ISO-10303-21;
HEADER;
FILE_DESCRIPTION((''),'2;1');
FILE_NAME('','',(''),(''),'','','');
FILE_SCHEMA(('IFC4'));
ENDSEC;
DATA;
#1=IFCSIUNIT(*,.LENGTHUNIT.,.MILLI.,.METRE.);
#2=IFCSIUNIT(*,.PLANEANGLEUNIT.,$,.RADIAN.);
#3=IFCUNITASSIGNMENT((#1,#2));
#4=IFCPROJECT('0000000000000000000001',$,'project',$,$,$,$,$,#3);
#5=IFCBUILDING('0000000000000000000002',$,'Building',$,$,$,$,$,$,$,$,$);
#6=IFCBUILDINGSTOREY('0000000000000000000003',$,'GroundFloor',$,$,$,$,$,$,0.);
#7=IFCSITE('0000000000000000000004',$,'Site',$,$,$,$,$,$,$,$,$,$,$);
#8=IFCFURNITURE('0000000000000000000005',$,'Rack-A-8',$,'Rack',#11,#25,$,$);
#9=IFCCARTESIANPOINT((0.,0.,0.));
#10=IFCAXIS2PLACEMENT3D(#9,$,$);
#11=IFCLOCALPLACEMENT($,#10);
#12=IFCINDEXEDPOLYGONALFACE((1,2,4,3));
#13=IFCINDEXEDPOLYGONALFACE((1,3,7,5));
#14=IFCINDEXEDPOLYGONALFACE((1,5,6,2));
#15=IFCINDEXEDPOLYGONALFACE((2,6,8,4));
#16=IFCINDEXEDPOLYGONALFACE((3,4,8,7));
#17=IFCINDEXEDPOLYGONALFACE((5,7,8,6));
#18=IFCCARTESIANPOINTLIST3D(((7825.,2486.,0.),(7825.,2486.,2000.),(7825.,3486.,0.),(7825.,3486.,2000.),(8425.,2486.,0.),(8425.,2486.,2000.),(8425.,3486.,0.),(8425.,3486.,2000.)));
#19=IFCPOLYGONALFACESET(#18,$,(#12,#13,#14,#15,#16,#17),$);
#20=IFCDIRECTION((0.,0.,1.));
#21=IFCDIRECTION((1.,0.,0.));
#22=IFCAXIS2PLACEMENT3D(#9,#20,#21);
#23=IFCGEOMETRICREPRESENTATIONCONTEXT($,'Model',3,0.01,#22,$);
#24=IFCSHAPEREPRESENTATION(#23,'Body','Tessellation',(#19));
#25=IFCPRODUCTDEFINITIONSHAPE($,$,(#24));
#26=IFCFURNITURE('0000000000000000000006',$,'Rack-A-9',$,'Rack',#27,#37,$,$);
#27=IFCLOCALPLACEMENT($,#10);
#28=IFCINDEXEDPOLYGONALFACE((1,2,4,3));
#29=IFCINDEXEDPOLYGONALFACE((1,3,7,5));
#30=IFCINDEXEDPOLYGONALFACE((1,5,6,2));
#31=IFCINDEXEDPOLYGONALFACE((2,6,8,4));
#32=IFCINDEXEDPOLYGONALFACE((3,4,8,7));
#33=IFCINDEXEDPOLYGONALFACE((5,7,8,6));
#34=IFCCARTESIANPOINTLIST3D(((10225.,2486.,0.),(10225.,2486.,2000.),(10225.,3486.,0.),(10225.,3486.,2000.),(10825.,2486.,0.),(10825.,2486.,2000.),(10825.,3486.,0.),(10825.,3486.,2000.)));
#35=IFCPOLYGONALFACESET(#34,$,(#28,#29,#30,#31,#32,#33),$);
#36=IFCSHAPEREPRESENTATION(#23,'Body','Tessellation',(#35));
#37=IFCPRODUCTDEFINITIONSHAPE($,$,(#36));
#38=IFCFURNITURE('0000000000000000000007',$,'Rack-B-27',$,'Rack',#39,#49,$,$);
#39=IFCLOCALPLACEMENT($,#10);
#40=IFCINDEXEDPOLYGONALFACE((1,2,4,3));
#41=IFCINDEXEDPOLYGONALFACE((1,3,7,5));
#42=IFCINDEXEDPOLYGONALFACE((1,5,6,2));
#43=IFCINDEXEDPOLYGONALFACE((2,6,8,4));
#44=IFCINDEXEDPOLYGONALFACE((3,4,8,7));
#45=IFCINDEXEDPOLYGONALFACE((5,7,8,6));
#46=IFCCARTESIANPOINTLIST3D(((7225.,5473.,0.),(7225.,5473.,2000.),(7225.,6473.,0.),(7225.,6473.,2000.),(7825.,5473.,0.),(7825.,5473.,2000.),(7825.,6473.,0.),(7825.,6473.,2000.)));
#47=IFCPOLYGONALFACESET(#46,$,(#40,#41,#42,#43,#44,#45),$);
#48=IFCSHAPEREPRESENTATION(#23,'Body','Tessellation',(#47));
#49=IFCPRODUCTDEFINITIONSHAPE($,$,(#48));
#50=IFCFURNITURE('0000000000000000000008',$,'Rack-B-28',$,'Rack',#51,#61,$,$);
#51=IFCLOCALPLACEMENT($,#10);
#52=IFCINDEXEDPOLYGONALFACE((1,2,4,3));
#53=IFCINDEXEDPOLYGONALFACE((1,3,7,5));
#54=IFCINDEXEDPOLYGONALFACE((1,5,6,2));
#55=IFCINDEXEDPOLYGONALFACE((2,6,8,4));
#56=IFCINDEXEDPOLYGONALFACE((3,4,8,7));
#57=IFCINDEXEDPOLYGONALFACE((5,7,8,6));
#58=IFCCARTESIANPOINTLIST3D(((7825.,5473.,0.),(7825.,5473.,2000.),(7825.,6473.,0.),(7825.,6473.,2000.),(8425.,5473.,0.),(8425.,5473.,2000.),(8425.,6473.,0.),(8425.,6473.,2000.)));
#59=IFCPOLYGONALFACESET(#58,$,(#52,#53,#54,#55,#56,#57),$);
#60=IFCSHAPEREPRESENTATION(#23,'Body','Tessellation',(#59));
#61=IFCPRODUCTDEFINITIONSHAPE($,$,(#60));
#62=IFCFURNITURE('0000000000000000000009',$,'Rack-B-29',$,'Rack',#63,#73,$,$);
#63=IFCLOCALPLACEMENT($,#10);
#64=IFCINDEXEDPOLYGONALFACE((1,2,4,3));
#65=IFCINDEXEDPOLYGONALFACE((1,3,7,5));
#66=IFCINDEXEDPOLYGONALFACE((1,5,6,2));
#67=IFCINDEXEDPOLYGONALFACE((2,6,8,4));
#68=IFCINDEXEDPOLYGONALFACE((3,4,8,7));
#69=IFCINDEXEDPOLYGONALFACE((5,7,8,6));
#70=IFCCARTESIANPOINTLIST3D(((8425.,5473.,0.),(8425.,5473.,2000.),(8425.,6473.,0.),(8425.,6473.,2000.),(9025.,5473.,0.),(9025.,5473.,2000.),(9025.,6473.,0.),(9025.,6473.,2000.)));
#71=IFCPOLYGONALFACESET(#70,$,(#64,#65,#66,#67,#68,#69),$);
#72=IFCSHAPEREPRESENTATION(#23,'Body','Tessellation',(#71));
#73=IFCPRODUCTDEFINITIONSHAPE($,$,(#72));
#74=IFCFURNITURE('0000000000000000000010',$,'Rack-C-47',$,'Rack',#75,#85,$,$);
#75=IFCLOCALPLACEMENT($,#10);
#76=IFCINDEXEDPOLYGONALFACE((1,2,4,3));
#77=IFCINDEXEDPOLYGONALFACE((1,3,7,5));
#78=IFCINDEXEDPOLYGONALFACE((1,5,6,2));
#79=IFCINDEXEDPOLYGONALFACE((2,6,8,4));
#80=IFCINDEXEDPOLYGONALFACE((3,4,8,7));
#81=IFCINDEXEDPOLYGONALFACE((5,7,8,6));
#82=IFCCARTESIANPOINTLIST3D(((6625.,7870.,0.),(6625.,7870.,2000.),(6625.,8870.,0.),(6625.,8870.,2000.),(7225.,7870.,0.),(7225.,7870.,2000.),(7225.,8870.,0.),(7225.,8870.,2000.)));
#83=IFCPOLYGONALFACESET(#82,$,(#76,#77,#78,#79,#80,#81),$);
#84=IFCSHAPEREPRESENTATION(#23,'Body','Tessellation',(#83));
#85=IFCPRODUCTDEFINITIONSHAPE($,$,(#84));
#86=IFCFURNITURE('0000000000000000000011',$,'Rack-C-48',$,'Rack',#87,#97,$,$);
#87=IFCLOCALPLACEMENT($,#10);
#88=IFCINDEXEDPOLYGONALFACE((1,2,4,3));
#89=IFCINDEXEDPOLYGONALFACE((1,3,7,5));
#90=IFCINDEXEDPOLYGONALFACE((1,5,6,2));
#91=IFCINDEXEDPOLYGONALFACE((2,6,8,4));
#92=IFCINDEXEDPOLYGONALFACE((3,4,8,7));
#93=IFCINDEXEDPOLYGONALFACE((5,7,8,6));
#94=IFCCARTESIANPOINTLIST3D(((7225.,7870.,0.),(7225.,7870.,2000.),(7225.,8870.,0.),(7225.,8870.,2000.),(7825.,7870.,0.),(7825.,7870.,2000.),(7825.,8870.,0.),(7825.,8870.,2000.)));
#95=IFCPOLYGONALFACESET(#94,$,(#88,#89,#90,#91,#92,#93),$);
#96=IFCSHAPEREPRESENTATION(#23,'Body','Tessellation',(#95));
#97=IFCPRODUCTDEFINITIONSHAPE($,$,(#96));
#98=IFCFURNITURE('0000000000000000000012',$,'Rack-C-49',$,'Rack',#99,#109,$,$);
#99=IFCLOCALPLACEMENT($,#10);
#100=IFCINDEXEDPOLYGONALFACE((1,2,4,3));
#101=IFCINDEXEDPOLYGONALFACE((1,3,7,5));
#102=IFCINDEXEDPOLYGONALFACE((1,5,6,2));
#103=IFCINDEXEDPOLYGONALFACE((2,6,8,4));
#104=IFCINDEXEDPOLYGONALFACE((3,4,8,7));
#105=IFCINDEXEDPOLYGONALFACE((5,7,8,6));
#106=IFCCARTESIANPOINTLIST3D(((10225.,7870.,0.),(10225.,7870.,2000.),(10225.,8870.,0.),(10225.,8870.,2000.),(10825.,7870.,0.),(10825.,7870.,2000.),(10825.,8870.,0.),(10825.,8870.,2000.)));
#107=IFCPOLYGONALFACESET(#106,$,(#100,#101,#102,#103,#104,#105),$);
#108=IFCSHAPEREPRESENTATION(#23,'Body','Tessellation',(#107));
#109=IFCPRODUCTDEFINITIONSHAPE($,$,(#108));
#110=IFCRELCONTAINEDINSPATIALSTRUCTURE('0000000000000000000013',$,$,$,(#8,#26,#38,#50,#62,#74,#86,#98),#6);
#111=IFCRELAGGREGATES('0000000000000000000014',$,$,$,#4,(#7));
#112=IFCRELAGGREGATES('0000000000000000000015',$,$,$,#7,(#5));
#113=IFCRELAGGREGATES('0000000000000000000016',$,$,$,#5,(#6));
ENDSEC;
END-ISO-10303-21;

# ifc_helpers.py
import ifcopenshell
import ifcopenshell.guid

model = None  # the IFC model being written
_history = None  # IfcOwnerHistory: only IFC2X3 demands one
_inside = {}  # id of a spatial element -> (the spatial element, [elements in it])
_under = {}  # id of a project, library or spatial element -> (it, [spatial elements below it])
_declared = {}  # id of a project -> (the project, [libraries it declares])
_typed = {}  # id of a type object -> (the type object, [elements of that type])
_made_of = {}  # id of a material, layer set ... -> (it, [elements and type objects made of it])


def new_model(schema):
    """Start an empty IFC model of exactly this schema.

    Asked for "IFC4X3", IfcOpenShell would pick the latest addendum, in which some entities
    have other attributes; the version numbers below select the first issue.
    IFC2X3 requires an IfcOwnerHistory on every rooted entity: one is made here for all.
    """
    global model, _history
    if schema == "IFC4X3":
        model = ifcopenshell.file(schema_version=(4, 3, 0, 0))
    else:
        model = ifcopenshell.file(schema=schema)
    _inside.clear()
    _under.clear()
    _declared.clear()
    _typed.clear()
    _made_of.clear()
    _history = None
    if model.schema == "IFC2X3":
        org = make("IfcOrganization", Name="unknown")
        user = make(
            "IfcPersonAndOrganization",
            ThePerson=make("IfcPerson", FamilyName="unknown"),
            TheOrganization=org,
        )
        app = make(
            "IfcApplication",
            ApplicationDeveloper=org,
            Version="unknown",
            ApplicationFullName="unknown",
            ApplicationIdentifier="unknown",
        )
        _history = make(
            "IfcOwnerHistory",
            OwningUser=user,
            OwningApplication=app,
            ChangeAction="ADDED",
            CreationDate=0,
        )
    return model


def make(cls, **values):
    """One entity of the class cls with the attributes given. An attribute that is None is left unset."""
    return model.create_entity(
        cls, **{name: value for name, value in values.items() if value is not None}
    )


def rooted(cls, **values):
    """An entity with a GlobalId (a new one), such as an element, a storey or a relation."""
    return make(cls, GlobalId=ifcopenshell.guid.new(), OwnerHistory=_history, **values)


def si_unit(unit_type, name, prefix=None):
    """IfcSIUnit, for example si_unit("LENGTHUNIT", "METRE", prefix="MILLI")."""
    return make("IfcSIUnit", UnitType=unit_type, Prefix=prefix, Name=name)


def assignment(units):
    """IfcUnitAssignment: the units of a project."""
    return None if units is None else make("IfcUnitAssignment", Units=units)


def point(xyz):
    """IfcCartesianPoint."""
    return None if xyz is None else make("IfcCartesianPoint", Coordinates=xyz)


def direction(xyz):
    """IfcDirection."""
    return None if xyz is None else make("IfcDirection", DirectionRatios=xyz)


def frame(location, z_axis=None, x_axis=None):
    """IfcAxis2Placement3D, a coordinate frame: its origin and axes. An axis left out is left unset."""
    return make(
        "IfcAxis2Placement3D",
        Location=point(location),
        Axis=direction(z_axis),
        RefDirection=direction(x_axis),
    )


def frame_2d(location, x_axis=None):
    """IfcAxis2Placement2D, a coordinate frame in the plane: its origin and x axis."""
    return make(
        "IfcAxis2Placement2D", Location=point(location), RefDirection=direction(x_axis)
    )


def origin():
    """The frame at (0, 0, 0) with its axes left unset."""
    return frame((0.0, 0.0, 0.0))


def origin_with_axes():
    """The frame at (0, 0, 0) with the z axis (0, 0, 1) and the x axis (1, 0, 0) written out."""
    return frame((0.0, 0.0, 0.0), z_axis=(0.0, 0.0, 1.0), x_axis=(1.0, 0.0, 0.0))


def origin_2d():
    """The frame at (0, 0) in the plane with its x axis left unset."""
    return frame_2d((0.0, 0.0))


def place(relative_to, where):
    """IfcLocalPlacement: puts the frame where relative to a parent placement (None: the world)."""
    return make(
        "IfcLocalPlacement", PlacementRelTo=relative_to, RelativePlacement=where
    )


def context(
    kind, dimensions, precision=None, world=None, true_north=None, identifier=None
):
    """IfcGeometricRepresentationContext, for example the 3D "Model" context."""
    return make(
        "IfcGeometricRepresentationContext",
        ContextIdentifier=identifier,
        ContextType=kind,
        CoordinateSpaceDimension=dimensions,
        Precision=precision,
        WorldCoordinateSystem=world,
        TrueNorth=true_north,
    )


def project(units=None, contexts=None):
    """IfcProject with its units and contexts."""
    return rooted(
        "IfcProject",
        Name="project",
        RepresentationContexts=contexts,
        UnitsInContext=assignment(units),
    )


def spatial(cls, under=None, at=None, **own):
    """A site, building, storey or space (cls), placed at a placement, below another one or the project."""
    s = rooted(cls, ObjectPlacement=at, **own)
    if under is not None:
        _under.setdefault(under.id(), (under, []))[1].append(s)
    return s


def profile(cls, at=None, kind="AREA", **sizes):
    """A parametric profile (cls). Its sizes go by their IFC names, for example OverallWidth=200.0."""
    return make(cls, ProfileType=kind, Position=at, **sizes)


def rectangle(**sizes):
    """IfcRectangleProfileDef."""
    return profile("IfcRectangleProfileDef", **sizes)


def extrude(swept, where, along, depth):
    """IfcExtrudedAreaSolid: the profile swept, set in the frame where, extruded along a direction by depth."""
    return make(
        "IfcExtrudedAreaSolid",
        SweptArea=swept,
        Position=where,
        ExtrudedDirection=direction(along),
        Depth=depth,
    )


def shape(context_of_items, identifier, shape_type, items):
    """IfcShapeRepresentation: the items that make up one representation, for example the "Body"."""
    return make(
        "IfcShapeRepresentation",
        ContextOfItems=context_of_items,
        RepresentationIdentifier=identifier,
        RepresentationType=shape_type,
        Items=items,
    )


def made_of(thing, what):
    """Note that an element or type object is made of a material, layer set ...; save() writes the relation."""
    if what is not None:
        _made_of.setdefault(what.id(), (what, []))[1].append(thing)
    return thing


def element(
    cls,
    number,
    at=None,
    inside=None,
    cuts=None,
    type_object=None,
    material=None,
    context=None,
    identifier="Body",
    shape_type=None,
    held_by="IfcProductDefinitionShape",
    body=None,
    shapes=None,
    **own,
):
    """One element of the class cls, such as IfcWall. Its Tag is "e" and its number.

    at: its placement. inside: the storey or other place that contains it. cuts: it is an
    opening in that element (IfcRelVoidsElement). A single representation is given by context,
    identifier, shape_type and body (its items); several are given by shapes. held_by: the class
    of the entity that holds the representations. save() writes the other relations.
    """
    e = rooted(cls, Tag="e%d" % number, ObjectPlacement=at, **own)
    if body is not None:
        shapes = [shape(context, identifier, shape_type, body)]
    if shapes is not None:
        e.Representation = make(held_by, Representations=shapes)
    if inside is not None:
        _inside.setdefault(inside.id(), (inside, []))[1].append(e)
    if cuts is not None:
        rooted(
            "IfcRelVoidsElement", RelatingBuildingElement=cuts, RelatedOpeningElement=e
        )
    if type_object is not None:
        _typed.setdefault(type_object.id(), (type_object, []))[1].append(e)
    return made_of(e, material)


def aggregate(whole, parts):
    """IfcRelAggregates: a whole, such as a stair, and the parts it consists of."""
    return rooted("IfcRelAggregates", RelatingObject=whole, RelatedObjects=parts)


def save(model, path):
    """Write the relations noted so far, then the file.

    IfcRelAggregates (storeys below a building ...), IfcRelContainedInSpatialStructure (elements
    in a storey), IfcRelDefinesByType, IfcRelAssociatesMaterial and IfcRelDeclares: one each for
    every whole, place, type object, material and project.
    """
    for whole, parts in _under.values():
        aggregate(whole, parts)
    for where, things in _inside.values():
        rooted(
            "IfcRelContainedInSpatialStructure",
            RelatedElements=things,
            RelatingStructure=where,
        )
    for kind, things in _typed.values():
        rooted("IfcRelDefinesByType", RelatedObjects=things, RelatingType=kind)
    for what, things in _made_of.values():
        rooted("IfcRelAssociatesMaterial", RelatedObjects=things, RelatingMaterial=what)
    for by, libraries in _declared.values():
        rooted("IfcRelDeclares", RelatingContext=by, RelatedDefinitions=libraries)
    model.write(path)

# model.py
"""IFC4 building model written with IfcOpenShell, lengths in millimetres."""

from ifc_helpers import new_model, si_unit, frame, origin, origin_with_axes, origin_2d, place, context, project, spatial, rectangle, extrude, element, save


model = new_model("IFC4")

# Units and contexts
model_context = context("Model", 3, precision=0.01, world=origin_with_axes())
ifc_project = project(units=[si_unit("LENGTHUNIT", "METRE", prefix="MILLI"), si_unit("PLANEANGLEUNIT", "RADIAN")])

# Site, building, storey
site = spatial("IfcSite", under=ifc_project, Name="Site")
building = spatial("IfcBuilding", under=site, Name="Building")
storey = spatial("IfcBuildingStorey", under=building, Name="GroundFloor", Elevation=0.0)

# Furniture
for number, where, z_axis, x_axis, name in (
    (1, (8125.0, 2986.0, 0.0), (0.0, 0.0, 1.0), (1.0, 0.0, 0.0), "Rack-A-8"),
    (2, (10525.0, 2986.0, 0.0), (0.0, 0.0, 1.0), (1.0, 0.0, 0.0), "Rack-A-9"),
    (3, (7525.0, 5973.0, 0.0), (0.0, 0.0, 1.0), (1.0, 0.0, 0.0), "Rack-B-27"),
    (4, (8125.0, 5973.0, 0.0), (0.0, 0.0, 1.0), (1.0, 0.0, 0.0), "Rack-B-28"),
    (5, (8725.0, 5973.0, 0.0), (0.0, 0.0, 1.0), (1.0, 0.0, 0.0), "Rack-B-29"),
    (6, (6925.0, 8370.0, 0.0), (0.0, 0.0, 1.0), (1.0, 0.0, 0.0), "Rack-C-47"),
    (7, (7525.0, 8370.0, 0.0), (0.0, 0.0, 1.0), (1.0, 0.0, 0.0), "Rack-C-48"),
    (8, (10525.0, 8370.0, 0.0), (0.0, 0.0, 1.0), (1.0, 0.0, 0.0), "Rack-C-49"),
):
    element("IfcFurniture", number, at=place(None, frame(where, z_axis=z_axis, x_axis=x_axis)), inside=storey, Name=name, ObjectType="Rack", context=model_context, shape_type="SweptSolid", body=[
        extrude(rectangle(XDim=600.0, YDim=1000.0, at=origin_2d()), origin(), (0.0, 0.0, 1.0), 2000.0),
    ])

save(model, "model.ifc")
